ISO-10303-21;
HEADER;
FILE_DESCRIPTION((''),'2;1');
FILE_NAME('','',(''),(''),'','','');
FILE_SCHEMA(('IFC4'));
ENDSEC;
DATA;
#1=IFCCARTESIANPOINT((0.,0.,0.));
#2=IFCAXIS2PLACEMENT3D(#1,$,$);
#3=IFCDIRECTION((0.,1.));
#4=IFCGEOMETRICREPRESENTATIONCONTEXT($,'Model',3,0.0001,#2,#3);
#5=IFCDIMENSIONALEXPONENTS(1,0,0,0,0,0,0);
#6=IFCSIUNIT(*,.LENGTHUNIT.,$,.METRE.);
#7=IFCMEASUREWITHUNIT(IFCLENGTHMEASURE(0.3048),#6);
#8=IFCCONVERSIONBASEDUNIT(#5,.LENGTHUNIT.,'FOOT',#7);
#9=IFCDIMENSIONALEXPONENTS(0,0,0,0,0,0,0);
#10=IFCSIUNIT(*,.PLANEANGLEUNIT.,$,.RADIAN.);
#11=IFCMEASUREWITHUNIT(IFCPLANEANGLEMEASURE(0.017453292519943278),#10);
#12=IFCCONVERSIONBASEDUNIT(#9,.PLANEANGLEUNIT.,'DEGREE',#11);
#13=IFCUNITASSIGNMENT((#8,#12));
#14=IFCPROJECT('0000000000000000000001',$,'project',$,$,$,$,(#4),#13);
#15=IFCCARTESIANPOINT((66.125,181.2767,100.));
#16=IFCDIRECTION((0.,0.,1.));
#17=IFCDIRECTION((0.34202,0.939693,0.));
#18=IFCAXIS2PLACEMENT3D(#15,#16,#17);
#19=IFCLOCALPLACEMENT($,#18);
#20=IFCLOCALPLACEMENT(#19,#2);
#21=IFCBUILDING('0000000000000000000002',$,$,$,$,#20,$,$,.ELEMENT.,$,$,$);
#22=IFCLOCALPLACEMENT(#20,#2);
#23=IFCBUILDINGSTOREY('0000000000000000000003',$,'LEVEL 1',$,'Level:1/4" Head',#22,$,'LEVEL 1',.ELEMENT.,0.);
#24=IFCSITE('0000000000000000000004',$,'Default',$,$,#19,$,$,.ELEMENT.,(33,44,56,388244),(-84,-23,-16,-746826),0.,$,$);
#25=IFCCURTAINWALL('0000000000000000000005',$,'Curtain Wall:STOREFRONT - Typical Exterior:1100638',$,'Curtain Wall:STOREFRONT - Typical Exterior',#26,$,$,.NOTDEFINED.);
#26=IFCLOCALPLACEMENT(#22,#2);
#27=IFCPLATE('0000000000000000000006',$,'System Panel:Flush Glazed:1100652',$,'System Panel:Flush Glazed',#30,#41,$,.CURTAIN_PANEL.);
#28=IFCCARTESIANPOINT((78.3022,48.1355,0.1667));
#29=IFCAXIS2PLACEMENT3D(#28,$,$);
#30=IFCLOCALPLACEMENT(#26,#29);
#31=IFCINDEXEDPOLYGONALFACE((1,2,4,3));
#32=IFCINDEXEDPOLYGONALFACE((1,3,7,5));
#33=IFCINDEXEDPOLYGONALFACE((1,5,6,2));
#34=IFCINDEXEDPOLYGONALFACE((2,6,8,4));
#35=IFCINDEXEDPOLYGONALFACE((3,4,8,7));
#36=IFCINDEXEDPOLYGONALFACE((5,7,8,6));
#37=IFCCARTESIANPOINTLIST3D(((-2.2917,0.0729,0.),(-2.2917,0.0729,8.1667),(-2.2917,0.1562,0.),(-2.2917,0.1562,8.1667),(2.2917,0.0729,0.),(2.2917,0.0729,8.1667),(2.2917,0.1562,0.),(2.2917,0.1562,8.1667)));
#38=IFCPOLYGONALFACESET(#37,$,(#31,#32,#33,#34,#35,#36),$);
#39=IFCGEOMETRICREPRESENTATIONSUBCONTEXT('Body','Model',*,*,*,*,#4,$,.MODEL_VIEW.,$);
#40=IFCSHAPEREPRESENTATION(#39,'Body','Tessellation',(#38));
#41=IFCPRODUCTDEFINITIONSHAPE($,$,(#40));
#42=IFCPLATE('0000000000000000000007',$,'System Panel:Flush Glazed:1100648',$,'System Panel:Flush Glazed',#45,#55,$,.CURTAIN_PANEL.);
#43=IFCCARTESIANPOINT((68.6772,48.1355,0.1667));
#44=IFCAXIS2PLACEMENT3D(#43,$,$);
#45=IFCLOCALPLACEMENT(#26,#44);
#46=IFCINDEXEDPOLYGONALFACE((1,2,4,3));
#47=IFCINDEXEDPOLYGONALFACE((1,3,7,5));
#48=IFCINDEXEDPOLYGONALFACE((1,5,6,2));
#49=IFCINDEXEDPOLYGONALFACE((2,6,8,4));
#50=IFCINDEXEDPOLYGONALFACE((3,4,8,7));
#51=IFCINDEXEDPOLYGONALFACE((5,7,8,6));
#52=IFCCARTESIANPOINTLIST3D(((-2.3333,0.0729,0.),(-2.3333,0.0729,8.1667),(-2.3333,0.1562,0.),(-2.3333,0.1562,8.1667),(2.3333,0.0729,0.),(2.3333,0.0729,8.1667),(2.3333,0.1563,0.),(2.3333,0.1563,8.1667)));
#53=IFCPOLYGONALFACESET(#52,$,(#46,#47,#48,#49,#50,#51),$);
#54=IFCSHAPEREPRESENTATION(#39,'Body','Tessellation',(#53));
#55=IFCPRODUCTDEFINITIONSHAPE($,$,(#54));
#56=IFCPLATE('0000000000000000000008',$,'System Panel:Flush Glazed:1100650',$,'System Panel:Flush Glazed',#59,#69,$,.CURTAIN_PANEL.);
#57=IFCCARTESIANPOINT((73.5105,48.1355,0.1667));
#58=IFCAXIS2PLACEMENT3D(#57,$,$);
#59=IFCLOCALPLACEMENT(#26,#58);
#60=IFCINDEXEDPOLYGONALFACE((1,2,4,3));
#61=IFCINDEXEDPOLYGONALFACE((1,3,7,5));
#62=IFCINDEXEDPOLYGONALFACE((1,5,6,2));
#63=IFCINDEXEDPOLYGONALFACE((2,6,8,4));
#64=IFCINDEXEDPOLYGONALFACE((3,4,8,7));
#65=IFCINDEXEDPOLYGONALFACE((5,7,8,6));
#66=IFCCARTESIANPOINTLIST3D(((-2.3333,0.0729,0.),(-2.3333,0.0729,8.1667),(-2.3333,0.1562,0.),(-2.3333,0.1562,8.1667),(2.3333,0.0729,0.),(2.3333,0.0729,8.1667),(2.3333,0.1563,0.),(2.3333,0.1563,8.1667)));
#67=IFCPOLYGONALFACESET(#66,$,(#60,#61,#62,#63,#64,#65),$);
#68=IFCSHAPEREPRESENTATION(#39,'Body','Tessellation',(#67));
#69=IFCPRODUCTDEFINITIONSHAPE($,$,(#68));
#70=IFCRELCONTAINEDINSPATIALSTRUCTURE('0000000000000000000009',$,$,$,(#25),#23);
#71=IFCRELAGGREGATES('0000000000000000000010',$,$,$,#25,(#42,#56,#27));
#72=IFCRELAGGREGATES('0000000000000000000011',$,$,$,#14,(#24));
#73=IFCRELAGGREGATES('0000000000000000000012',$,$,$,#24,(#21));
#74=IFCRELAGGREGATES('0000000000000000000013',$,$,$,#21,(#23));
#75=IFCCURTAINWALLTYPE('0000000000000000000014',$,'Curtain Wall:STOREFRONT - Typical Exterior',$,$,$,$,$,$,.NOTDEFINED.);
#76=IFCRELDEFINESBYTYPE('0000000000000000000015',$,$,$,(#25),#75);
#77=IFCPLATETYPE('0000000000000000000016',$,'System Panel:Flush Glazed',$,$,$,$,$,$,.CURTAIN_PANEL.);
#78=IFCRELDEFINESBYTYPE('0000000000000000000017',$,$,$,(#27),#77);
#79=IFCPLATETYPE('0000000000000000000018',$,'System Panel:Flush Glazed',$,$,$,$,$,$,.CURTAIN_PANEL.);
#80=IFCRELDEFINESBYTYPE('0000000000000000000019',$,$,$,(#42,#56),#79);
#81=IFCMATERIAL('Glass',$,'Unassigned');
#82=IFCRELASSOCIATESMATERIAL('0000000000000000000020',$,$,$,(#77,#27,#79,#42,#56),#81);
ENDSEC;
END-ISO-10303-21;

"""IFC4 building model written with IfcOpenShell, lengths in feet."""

from ifc_helpers import new_model, entity, si_unit, converted_unit, direction, frame, frame_2d, origin, place, context, subcontext, project, spatial, rectangle, extrude, source, transform, mapped, material, type_object, type_shapes, element, aggregate, save


model = new_model("IFC4")

# Units and contexts
model_context = context("Model", 3, precision=0.0001, world=origin(), true_north=direction((0.0, 1.0)))
body_context = subcontext(model_context, "Body", "Model", "MODEL_VIEW")
ifc_project = project(units=[converted_unit("LENGTHUNIT", "FOOT", entity("IfcLengthMeasure", 0.3048), si_unit("LENGTHUNIT", "METRE"), dimensions=[1, 0, 0, 0, 0, 0, 0]), converted_unit("PLANEANGLEUNIT", "DEGREE", entity("IfcPlaneAngleMeasure", 0.017453292519943278), si_unit("PLANEANGLEUNIT", "RADIAN"), dimensions=[0, 0, 0, 0, 0, 0, 0])], contexts=[model_context])

# Site, building, storey
site_placement = place(None, frame((66.125, 181.2767, 100.0), z_axis=(0.0, 0.0, 1.0), x_axis=(0.34202, 0.939693, 0.0)))
site = spatial("IfcSite", under=ifc_project, at=site_placement, Name="Default", CompositionType="ELEMENT", RefLatitude=(33, 44, 56, 388244), RefLongitude=(-84, -23, -16, -746826), RefElevation=0.0)
building_placement = place(site_placement, origin())
building = spatial("IfcBuilding", under=site, at=building_placement, CompositionType="ELEMENT")
storey_placement = place(building_placement, origin())
storey = spatial("IfcBuildingStorey", under=building, at=storey_placement, Name="LEVEL 1", ObjectType="Level:1/4\" Head", LongName="LEVEL 1", CompositionType="ELEMENT", Elevation=0.0)

# Curtain wall
curtain_wall_type = type_object("IfcCurtainWallType", Name="Curtain Wall:STOREFRONT - Typical Exterior", PredefinedType="NOTDEFINED")
curtain_wall_1_placement = place(storey_placement, origin())
curtain_wall_1 = element("IfcCurtainWall", 1, at=curtain_wall_1_placement, inside=storey, type_object=curtain_wall_type, Name="Curtain Wall:STOREFRONT - Typical Exterior:1100638", ObjectType="Curtain Wall:STOREFRONT - Typical Exterior", PredefinedType="NOTDEFINED")

# Plates
ifc_material_1 = material(Name="Glass", Category="Unassigned")
plate_type_1 = type_object("IfcPlateType", Name="System Panel:Flush Glazed", PredefinedType="CURTAIN_PANEL", material=ifc_material_1)
shared_shape_1 = source(origin(), body_context, "Body", "SweptSolid", [
    extrude(rectangle(XDim=0.0833, YDim=4.5833, at=frame_2d((0.0, 0.0), x_axis=(1.0, 0.0))), frame((0.0, 0.1146, 0.0), z_axis=(0.0, 0.0, 1.0), x_axis=(0.0, 1.0, 0.0)), (0.0, 0.0, 1.0), 8.1667),
])
type_shapes(plate_type_1, [shared_shape_1])
plate_1_placement = place(curtain_wall_1_placement, frame((78.3022, 48.1355, 0.1667)))
plate_1 = element("IfcPlate", 2, at=plate_1_placement, type_object=plate_type_1, material=ifc_material_1, Name="System Panel:Flush Glazed:1100652", ObjectType="System Panel:Flush Glazed", PredefinedType="CURTAIN_PANEL", context=body_context, shape_type="MappedRepresentation", body=[
    mapped(shared_shape_1, transform((0.0, 0.0, 0.0), scale=1.0)),
])
plate_type_2 = type_object("IfcPlateType", Name="System Panel:Flush Glazed", PredefinedType="CURTAIN_PANEL", material=ifc_material_1)
shared_shape_2 = source(origin(), body_context, "Body", "SweptSolid", [
    extrude(rectangle(XDim=0.0833, YDim=4.6667, at=frame_2d((0.0, 0.0), x_axis=(1.0, 0.0))), frame((0.0, 0.1146, 0.0), z_axis=(0.0, 0.0, 1.0), x_axis=(0.0, 1.0, 0.0)), (0.0, 0.0, 1.0), 8.1667),
])
type_shapes(plate_type_2, [shared_shape_2])
plate_2_placement = place(curtain_wall_1_placement, frame((68.6772, 48.1355, 0.1667)))
plate_2 = element("IfcPlate", 3, at=plate_2_placement, type_object=plate_type_2, material=ifc_material_1, Name="System Panel:Flush Glazed:1100648", ObjectType="System Panel:Flush Glazed", PredefinedType="CURTAIN_PANEL", context=body_context, shape_type="MappedRepresentation", body=[
    mapped(shared_shape_2, transform((0.0, 0.0, 0.0), scale=1.0)),
])
plate_3_placement = place(curtain_wall_1_placement, frame((73.5105, 48.1355, 0.1667)))
plate_3 = element("IfcPlate", 4, at=plate_3_placement, type_object=plate_type_2, material=ifc_material_1, Name="System Panel:Flush Glazed:1100650", ObjectType="System Panel:Flush Glazed", PredefinedType="CURTAIN_PANEL", context=body_context, shape_type="MappedRepresentation", body=[
    mapped(shared_shape_2, transform((0.0, 0.0, 0.0), scale=1.0)),
])
aggregate(curtain_wall_1, [plate_2, plate_3, plate_1])

save(model, "model.ifc")
